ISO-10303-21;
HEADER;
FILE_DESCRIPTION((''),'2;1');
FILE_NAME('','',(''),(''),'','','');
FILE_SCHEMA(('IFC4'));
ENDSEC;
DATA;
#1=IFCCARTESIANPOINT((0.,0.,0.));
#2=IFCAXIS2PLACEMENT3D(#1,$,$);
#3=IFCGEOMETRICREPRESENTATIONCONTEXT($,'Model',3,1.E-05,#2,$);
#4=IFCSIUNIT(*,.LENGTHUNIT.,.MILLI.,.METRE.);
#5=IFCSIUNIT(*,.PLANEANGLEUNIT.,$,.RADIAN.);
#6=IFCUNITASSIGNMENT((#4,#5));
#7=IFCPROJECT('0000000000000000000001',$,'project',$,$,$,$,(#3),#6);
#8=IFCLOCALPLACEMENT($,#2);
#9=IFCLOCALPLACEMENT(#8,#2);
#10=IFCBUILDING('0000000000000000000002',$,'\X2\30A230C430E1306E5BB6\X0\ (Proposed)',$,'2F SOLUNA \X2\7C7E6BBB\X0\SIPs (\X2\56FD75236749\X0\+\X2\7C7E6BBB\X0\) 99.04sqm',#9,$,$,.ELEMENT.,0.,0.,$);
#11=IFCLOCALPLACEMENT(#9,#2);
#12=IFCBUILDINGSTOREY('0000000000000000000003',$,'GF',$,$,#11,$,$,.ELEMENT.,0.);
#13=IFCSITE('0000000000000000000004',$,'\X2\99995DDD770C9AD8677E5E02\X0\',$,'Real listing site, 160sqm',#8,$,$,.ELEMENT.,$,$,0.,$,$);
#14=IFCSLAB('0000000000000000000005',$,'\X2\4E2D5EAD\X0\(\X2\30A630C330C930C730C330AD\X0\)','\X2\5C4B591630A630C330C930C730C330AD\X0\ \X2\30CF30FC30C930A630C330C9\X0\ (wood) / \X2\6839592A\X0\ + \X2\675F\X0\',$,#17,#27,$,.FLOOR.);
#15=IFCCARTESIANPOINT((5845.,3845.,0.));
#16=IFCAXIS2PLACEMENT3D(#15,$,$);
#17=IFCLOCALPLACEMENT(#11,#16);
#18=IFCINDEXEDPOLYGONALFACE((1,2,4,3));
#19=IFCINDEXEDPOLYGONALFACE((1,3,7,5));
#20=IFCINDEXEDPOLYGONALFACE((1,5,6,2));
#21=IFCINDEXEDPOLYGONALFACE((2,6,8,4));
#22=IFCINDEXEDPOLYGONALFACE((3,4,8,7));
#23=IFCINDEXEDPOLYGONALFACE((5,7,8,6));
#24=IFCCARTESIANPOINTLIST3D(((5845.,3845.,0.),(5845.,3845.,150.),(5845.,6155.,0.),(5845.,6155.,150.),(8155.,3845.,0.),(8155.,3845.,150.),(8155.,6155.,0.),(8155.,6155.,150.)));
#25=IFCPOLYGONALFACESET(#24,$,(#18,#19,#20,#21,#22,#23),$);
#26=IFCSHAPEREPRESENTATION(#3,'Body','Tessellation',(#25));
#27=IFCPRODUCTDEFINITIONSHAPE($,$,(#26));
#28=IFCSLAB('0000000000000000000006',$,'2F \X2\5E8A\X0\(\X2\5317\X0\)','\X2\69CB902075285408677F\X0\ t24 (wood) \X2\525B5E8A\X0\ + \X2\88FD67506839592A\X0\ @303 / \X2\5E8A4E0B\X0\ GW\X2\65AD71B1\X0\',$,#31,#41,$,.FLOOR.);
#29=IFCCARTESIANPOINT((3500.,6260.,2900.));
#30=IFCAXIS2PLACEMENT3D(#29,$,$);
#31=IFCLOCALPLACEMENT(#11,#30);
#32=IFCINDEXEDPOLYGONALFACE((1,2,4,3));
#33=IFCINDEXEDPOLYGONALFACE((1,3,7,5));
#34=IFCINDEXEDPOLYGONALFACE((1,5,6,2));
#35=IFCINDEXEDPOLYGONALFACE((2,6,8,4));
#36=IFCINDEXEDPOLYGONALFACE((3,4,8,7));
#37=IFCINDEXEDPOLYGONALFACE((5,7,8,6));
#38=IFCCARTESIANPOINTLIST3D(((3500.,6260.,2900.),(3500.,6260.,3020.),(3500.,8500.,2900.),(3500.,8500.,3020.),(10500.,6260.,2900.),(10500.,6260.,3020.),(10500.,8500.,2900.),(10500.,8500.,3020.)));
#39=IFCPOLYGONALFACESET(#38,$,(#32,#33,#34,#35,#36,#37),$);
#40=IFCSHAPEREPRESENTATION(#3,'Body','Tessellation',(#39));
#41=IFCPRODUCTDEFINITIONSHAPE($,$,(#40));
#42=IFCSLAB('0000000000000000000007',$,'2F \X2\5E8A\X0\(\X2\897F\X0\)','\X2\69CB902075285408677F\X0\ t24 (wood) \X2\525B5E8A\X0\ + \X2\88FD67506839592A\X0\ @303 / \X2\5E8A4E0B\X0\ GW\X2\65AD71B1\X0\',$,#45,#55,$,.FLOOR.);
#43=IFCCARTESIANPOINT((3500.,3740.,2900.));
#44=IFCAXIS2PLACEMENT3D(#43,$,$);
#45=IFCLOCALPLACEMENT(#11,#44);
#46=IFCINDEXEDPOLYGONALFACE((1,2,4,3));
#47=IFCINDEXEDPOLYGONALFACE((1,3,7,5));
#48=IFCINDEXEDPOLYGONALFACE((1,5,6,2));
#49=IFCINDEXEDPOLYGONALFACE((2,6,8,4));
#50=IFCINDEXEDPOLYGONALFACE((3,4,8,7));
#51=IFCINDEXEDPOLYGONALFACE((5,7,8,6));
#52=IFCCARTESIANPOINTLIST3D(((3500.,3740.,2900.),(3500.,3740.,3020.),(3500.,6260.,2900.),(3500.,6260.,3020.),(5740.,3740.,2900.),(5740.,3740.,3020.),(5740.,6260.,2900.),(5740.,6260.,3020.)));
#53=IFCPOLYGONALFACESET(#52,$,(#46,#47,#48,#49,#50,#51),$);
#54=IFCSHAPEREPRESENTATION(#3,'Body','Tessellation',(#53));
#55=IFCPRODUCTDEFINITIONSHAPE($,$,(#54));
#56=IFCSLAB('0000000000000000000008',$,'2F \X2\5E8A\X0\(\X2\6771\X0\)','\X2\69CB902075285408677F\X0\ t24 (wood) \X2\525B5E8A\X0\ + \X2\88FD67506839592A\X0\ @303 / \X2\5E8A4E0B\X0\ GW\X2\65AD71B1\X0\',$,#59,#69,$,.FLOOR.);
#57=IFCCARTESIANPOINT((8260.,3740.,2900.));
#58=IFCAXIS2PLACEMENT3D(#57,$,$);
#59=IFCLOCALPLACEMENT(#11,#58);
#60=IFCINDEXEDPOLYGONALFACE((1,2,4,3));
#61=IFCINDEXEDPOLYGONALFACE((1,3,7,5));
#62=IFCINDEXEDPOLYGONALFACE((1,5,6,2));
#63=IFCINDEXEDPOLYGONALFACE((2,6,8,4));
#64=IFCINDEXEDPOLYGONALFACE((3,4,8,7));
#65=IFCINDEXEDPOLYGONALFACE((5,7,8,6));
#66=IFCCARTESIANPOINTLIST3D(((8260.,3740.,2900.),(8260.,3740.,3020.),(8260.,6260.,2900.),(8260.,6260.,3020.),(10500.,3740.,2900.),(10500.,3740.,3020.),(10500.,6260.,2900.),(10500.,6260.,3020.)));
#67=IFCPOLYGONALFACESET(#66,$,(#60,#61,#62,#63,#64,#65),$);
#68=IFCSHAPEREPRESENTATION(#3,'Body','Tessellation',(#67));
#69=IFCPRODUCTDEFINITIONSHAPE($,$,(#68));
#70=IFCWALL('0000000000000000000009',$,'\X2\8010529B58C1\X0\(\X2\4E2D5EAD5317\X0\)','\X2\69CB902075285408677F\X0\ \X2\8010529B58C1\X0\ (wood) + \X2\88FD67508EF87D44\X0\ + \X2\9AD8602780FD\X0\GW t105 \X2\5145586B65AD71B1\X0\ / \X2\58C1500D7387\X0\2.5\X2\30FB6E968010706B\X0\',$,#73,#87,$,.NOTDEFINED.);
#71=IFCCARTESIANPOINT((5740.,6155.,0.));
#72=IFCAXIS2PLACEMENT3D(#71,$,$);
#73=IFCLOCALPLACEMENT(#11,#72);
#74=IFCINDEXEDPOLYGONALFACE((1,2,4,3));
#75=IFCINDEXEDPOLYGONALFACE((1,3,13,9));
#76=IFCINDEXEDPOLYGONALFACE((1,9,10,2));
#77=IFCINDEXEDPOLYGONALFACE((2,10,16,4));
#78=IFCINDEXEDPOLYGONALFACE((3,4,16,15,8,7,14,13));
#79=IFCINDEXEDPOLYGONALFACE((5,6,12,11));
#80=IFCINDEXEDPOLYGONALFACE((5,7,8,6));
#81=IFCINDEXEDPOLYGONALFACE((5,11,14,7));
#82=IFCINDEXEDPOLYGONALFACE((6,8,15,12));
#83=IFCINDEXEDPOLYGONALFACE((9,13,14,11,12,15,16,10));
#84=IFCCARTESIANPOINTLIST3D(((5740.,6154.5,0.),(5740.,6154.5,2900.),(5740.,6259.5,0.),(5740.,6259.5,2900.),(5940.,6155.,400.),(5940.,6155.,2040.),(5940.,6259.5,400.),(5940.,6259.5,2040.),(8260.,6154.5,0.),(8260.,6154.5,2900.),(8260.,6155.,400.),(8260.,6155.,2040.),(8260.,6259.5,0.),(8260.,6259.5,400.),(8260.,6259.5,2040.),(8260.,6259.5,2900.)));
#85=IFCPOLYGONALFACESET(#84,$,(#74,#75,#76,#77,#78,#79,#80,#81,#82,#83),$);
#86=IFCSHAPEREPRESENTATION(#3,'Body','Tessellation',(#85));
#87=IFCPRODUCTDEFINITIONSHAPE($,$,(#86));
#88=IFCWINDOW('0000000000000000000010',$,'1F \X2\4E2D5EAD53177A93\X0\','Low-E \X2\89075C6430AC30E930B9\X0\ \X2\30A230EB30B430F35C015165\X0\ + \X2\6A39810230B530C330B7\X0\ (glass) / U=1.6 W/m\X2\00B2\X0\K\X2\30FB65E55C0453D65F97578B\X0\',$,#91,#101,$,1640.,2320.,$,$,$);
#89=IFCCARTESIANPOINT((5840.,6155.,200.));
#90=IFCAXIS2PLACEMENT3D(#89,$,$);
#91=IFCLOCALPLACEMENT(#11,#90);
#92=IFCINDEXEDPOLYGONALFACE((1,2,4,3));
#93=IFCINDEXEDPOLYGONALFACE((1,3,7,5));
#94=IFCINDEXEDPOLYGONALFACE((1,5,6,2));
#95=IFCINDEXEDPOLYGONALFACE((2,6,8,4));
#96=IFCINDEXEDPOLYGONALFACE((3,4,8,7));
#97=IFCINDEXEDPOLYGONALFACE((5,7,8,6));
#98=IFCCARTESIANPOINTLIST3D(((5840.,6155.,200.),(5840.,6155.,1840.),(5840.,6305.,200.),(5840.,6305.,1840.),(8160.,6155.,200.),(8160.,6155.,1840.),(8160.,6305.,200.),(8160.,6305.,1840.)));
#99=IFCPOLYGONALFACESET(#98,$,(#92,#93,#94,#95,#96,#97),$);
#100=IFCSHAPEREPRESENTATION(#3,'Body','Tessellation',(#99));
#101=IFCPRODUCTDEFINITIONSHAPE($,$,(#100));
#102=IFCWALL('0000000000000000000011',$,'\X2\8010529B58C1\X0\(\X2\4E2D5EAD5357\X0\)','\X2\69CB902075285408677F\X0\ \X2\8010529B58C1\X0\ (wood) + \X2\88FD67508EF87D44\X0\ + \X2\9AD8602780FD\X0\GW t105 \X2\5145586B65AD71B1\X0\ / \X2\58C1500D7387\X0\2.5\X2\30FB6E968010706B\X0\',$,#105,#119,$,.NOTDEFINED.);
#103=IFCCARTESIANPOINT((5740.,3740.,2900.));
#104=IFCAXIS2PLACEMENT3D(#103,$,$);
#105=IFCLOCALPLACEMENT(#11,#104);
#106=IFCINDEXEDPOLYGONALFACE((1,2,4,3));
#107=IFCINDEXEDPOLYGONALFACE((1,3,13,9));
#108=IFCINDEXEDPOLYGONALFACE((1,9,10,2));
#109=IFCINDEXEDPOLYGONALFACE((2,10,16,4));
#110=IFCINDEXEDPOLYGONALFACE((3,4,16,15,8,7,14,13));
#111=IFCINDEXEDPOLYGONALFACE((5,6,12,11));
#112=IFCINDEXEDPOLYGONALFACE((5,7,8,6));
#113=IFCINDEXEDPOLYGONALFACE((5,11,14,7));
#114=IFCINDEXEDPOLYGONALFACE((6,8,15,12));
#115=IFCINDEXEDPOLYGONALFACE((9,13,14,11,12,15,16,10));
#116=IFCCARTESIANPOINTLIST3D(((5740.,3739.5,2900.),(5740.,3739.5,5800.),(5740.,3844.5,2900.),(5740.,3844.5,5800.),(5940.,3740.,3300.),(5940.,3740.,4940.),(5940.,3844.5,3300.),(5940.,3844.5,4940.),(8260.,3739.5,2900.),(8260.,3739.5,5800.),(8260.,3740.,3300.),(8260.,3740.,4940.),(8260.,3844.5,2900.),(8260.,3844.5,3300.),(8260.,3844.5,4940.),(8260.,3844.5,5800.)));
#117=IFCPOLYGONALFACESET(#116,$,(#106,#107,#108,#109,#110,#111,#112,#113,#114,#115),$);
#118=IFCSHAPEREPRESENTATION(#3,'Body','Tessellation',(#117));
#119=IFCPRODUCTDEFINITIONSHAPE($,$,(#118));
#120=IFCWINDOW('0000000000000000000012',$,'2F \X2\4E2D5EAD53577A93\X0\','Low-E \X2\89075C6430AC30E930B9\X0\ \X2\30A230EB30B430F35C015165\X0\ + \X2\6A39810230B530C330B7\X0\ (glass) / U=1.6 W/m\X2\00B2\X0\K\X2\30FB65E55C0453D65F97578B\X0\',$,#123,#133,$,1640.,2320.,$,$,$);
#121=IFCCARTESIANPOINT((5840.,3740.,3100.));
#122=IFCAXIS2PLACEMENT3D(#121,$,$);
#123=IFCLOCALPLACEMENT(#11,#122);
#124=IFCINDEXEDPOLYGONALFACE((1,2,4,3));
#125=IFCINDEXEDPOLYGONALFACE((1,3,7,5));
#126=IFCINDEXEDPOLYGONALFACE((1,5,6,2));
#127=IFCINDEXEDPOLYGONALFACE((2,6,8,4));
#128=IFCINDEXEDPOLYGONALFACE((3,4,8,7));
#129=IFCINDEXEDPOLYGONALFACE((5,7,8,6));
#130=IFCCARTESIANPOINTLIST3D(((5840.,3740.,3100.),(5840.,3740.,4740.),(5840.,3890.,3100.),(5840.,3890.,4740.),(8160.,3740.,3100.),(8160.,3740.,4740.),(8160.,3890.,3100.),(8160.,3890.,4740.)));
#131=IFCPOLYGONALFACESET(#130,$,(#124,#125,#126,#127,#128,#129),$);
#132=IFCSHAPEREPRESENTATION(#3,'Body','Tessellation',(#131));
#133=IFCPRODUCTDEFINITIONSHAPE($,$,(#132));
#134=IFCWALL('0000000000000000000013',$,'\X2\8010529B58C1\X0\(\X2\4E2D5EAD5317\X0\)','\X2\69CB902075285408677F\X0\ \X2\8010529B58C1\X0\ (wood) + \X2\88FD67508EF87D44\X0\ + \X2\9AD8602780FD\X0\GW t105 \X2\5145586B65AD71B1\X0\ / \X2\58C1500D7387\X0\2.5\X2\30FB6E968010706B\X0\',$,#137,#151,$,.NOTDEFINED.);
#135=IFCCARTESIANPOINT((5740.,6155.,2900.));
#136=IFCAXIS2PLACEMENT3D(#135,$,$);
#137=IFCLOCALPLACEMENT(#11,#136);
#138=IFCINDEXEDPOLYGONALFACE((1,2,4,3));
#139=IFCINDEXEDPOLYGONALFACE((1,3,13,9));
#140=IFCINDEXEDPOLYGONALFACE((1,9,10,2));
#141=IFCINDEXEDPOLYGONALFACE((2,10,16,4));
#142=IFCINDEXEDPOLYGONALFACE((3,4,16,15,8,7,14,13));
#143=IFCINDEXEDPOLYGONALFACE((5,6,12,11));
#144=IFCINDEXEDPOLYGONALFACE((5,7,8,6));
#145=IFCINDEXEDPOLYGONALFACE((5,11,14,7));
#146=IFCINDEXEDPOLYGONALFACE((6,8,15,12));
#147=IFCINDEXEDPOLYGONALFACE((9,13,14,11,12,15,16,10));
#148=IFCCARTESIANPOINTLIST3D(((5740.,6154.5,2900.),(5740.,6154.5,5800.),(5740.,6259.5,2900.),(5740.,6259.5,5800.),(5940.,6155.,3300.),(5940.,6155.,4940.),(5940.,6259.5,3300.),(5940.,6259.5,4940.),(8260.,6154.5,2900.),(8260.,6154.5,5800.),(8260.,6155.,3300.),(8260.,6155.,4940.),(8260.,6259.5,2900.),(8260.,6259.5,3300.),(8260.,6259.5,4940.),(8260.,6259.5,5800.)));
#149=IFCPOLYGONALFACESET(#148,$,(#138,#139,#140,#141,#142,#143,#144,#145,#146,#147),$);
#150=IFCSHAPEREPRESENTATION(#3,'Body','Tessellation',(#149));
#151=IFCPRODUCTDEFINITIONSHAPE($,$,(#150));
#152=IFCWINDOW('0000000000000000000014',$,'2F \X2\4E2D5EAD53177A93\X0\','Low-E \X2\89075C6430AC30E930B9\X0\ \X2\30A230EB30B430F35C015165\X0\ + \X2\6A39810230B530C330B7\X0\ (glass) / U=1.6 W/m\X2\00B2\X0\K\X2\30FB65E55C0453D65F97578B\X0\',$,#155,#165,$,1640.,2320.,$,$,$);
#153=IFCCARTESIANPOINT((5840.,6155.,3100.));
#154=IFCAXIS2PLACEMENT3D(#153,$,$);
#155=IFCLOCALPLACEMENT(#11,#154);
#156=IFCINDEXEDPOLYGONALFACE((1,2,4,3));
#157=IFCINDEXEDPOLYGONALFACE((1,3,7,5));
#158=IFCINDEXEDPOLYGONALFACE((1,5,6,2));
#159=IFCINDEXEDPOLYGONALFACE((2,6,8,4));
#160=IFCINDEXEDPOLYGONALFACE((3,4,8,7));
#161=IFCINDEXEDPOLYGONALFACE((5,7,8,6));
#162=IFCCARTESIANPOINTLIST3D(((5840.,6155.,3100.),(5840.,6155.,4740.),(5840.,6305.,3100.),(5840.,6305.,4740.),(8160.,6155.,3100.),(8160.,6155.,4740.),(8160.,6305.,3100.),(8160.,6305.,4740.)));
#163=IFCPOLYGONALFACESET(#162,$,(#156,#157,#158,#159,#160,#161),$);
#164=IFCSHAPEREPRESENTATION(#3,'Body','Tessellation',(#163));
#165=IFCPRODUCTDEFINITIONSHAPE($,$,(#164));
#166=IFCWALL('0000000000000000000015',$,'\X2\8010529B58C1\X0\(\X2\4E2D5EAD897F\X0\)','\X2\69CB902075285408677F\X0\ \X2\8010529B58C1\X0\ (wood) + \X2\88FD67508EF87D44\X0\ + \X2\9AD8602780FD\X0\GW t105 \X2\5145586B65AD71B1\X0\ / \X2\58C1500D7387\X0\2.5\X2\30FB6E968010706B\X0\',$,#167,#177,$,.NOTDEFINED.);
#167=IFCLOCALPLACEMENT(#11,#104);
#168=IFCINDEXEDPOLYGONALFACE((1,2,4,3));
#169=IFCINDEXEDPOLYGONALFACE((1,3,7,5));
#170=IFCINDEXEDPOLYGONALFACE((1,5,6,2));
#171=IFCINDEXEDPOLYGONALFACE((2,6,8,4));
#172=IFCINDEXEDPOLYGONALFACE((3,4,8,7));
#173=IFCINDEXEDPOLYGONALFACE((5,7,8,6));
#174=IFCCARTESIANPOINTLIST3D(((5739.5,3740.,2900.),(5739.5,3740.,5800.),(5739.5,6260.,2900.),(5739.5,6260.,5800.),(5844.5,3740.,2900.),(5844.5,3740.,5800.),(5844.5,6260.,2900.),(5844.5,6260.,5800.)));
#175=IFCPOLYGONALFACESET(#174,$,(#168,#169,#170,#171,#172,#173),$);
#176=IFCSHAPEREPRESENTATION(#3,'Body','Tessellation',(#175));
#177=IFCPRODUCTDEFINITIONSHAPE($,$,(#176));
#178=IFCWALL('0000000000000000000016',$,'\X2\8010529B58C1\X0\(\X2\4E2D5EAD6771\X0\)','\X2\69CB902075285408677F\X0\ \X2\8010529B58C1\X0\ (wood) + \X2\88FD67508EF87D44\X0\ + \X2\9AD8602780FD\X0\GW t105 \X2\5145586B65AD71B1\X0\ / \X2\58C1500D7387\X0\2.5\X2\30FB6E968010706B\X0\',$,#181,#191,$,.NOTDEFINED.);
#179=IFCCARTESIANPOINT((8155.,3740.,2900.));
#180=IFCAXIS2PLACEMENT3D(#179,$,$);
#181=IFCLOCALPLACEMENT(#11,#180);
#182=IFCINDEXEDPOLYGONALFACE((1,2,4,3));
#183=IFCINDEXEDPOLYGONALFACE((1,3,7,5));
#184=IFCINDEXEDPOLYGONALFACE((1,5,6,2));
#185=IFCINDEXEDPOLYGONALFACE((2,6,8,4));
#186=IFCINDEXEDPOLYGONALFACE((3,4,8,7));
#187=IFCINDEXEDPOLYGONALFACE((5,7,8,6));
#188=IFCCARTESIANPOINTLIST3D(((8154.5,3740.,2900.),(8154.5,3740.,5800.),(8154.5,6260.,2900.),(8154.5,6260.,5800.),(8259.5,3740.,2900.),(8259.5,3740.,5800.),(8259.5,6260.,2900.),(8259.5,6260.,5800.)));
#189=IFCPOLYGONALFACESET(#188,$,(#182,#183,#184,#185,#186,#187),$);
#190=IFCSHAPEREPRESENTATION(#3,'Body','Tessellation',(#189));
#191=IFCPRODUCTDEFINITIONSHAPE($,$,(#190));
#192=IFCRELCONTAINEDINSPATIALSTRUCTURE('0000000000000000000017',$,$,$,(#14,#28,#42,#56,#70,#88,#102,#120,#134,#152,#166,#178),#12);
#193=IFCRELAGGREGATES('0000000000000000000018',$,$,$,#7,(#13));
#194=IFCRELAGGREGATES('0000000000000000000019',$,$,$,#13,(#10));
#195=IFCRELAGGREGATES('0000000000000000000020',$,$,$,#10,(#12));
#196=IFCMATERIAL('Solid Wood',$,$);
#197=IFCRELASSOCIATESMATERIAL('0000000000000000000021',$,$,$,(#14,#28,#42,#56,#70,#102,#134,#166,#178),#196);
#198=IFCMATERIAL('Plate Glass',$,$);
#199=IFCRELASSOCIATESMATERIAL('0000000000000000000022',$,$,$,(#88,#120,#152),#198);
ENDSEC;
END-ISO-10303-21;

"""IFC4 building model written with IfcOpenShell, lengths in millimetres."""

from ifc_helpers import new_model, si_unit, frame, frame_2d, origin, place, context, project, spatial, rectangle, extrude, material, element, fill, save


model = new_model("IFC4")

# Units and contexts
model_context = context("Model", 3, precision=1e-05, world=origin())
ifc_project = project(units=[si_unit("LENGTHUNIT", "METRE", prefix="MILLI"), si_unit("PLANEANGLEUNIT", "RADIAN")], contexts=[model_context])

# Site, building, storey
site_placement = place(None, origin())
site = spatial("IfcSite", under=ifc_project, at=site_placement, Name="香川県高松市", ObjectType="Real listing site, 160sqm", CompositionType="ELEMENT", RefElevation=0.0)
building_placement = place(site_placement, origin())
building = spatial("IfcBuilding", under=site, at=building_placement, Name="アツメの家 (Proposed)", ObjectType="2F SOLUNA 籾殻SIPs (国産杉+籾殻) 99.04sqm", CompositionType="ELEMENT", ElevationOfRefHeight=0.0, ElevationOfTerrain=0.0)
storey_placement = place(building_placement, origin())
storey = spatial("IfcBuildingStorey", under=building, at=storey_placement, Name="GF", CompositionType="ELEMENT", Elevation=0.0)

# Slabs
ifc_material_1 = material(Name="Solid Wood")
slab_1_placement = place(storey_placement, frame((5845.0, 3845.0, 0.0)))
element("IfcSlab", 1, at=slab_1_placement, inside=storey, material=ifc_material_1, Name="中庭(ウッドデッキ)", Description="屋外ウッドデッキ ハードウッド (wood) / 根太 + 束", PredefinedType="FLOOR", context=model_context, shape_type="SweptSolid", body=[
    extrude(rectangle(XDim=2310.0, YDim=2310.0, at=frame_2d((1155.0, 1155.0))), frame((5845.0, 3845.0, 0.0)), (0.0, 0.0, 1.0), 150.0),
])
slab_2_placement = place(storey_placement, frame((3500.0, 6260.0, 2900.0)))
element("IfcSlab", 2, at=slab_2_placement, inside=storey, material=ifc_material_1, Name="2F 床(北)", Description="構造用合板 t24 (wood) 剛床 + 製材根太 @303 / 床下 GW断熱", PredefinedType="FLOOR", context=model_context, shape_type="SweptSolid", body=[
    extrude(rectangle(XDim=7000.0, YDim=2240.0, at=frame_2d((3500.0, 1120.0))), frame((3500.0, 6260.0, 2900.0)), (0.0, 0.0, 1.0), 120.0),
])
slab_3_placement = place(storey_placement, frame((3500.0, 3740.0, 2900.0)))
element("IfcSlab", 3, at=slab_3_placement, inside=storey, material=ifc_material_1, Name="2F 床(西)", Description="構造用合板 t24 (wood) 剛床 + 製材根太 @303 / 床下 GW断熱", PredefinedType="FLOOR", context=model_context, shape_type="SweptSolid", body=[
    extrude(rectangle(XDim=2240.0, YDim=2520.0, at=frame_2d((1120.0, 1260.0))), frame((3500.0, 3740.0, 2900.0)), (0.0, 0.0, 1.0), 120.0),
])
slab_4_placement = place(storey_placement, frame((8260.0, 3740.0, 2900.0)))
element("IfcSlab", 4, at=slab_4_placement, inside=storey, material=ifc_material_1, Name="2F 床(東)", Description="構造用合板 t24 (wood) 剛床 + 製材根太 @303 / 床下 GW断熱", PredefinedType="FLOOR", context=model_context, shape_type="SweptSolid", body=[
    extrude(rectangle(XDim=2240.0, YDim=2520.0, at=frame_2d((1120.0, 1260.0))), frame((8260.0, 3740.0, 2900.0)), (0.0, 0.0, 1.0), 120.0),
])

# Wall, opening, window
wall_1_placement = place(storey_placement, frame((5740.0, 6155.0, 0.0)))
wall_1 = element("IfcWall", 5, at=wall_1_placement, inside=storey, material=ifc_material_1, Name="耐力壁(中庭北)", Description="構造用合板 耐力壁 (wood) + 製材軸組 + 高性能GW t105 充填断熱 / 壁倍率2.5・準耐火", PredefinedType="NOTDEFINED", context=model_context, shape_type="SweptSolid", body=[
    extrude(rectangle(XDim=2520.0, YDim=105.0, at=frame_2d((1260.0, 52.0))), frame((5740.0, 6155.0, 0.0)), (0.0, 0.0, 1.0), 2900.0),
])
opening_1_placement = place(storey_placement, frame((5840.0, 6155.0, 200.0)))
opening_1 = element("IfcOpeningElement", 6, at=opening_1_placement, cuts=wall_1, PredefinedType="NOTDEFINED", context=model_context, shape_type="SweptSolid", body=[
    extrude(rectangle(XDim=2320.0, YDim=150.0, at=frame_2d((1160.0, 75.0))), frame((5840.0, 6155.0, 200.0)), (0.0, 0.0, 1.0), 1640.0),
])
ifc_material_2 = material(Name="Plate Glass")
window_1_placement = place(storey_placement, frame((5840.0, 6155.0, 200.0)))
window_1 = element("IfcWindow", 7, at=window_1_placement, inside=storey, material=ifc_material_2, Name="1F 中庭北窓", Description="Low-E 複層ガラス アルゴン封入 + 樹脂サッシ (glass) / U=1.6 W/m²K・日射取得型", OverallHeight=1640.0, OverallWidth=2320.0, context=model_context, shape_type="SweptSolid", body=[
    extrude(rectangle(XDim=2320.0, YDim=150.0, at=frame_2d((1160.0, 75.0))), frame((5840.0, 6155.0, 200.0)), (0.0, 0.0, 1.0), 1640.0),
])
fill(opening_1, window_1)

# Walls, openings, windows
wall_2_placement = place(storey_placement, frame((5740.0, 3740.0, 2900.0)))
wall_2 = element("IfcWall", 8, at=wall_2_placement, inside=storey, material=ifc_material_1, Name="耐力壁(中庭南)", Description="構造用合板 耐力壁 (wood) + 製材軸組 + 高性能GW t105 充填断熱 / 壁倍率2.5・準耐火", PredefinedType="NOTDEFINED", context=model_context, shape_type="SweptSolid", body=[
    extrude(rectangle(XDim=2520.0, YDim=105.0, at=frame_2d((1260.0, 52.0))), frame((5740.0, 3740.0, 2900.0)), (0.0, 0.0, 1.0), 2900.0),
])
opening_2_placement = place(storey_placement, frame((5840.0, 3740.0, 3100.0)))
opening_2 = element("IfcOpeningElement", 9, at=opening_2_placement, cuts=wall_2, PredefinedType="NOTDEFINED", context=model_context, shape_type="SweptSolid", body=[
    extrude(rectangle(XDim=2320.0, YDim=150.0, at=frame_2d((1160.0, 75.0))), frame((5840.0, 3740.0, 3100.0)), (0.0, 0.0, 1.0), 1640.0),
])
window_2_placement = place(storey_placement, frame((5840.0, 3740.0, 3100.0)))
window_2 = element("IfcWindow", 10, at=window_2_placement, inside=storey, material=ifc_material_2, Name="2F 中庭南窓", Description="Low-E 複層ガラス アルゴン封入 + 樹脂サッシ (glass) / U=1.6 W/m²K・日射取得型", OverallHeight=1640.0, OverallWidth=2320.0, context=model_context, shape_type="SweptSolid", body=[
    extrude(rectangle(XDim=2320.0, YDim=150.0, at=frame_2d((1160.0, 75.0))), frame((5840.0, 3740.0, 3100.0)), (0.0, 0.0, 1.0), 1640.0),
])
fill(opening_2, window_2)
wall_3_placement = place(storey_placement, frame((5740.0, 6155.0, 2900.0)))
wall_3 = element("IfcWall", 11, at=wall_3_placement, inside=storey, material=ifc_material_1, Name="耐力壁(中庭北)", Description="構造用合板 耐力壁 (wood) + 製材軸組 + 高性能GW t105 充填断熱 / 壁倍率2.5・準耐火", PredefinedType="NOTDEFINED", context=model_context, shape_type="SweptSolid", body=[
    extrude(rectangle(XDim=2520.0, YDim=105.0, at=frame_2d((1260.0, 52.0))), frame((5740.0, 6155.0, 2900.0)), (0.0, 0.0, 1.0), 2900.0),
])
opening_3_placement = place(storey_placement, frame((5840.0, 6155.0, 3100.0)))
opening_3 = element("IfcOpeningElement", 12, at=opening_3_placement, cuts=wall_3, PredefinedType="NOTDEFINED", context=model_context, shape_type="SweptSolid", body=[
    extrude(rectangle(XDim=2320.0, YDim=150.0, at=frame_2d((1160.0, 75.0))), frame((5840.0, 6155.0, 3100.0)), (0.0, 0.0, 1.0), 1640.0),
])
window_3_placement = place(storey_placement, frame((5840.0, 6155.0, 3100.0)))
window_3 = element("IfcWindow", 13, at=window_3_placement, inside=storey, material=ifc_material_2, Name="2F 中庭北窓", Description="Low-E 複層ガラス アルゴン封入 + 樹脂サッシ (glass) / U=1.6 W/m²K・日射取得型", OverallHeight=1640.0, OverallWidth=2320.0, context=model_context, shape_type="SweptSolid", body=[
    extrude(rectangle(XDim=2320.0, YDim=150.0, at=frame_2d((1160.0, 75.0))), frame((5840.0, 6155.0, 3100.0)), (0.0, 0.0, 1.0), 1640.0),
])
fill(opening_3, window_3)

# Walls
wall_4_placement = place(storey_placement, frame((5740.0, 3740.0, 2900.0)))
element("IfcWall", 14, at=wall_4_placement, inside=storey, material=ifc_material_1, Name="耐力壁(中庭西)", Description="構造用合板 耐力壁 (wood) + 製材軸組 + 高性能GW t105 充填断熱 / 壁倍率2.5・準耐火", PredefinedType="NOTDEFINED", context=model_context, shape_type="SweptSolid", body=[
    extrude(rectangle(XDim=105.0, YDim=2520.0, at=frame_2d((52.0, 1260.0))), frame((5740.0, 3740.0, 2900.0)), (0.0, 0.0, 1.0), 2900.0),
])
wall_5_placement = place(storey_placement, frame((8155.0, 3740.0, 2900.0)))
element("IfcWall", 15, at=wall_5_placement, inside=storey, material=ifc_material_1, Name="耐力壁(中庭東)", Description="構造用合板 耐力壁 (wood) + 製材軸組 + 高性能GW t105 充填断熱 / 壁倍率2.5・準耐火", PredefinedType="NOTDEFINED", context=model_context, shape_type="SweptSolid", body=[
    extrude(rectangle(XDim=105.0, YDim=2520.0, at=frame_2d((52.0, 1260.0))), frame((8155.0, 3740.0, 2900.0)), (0.0, 0.0, 1.0), 2900.0),
])

save(model, "model.ifc")
